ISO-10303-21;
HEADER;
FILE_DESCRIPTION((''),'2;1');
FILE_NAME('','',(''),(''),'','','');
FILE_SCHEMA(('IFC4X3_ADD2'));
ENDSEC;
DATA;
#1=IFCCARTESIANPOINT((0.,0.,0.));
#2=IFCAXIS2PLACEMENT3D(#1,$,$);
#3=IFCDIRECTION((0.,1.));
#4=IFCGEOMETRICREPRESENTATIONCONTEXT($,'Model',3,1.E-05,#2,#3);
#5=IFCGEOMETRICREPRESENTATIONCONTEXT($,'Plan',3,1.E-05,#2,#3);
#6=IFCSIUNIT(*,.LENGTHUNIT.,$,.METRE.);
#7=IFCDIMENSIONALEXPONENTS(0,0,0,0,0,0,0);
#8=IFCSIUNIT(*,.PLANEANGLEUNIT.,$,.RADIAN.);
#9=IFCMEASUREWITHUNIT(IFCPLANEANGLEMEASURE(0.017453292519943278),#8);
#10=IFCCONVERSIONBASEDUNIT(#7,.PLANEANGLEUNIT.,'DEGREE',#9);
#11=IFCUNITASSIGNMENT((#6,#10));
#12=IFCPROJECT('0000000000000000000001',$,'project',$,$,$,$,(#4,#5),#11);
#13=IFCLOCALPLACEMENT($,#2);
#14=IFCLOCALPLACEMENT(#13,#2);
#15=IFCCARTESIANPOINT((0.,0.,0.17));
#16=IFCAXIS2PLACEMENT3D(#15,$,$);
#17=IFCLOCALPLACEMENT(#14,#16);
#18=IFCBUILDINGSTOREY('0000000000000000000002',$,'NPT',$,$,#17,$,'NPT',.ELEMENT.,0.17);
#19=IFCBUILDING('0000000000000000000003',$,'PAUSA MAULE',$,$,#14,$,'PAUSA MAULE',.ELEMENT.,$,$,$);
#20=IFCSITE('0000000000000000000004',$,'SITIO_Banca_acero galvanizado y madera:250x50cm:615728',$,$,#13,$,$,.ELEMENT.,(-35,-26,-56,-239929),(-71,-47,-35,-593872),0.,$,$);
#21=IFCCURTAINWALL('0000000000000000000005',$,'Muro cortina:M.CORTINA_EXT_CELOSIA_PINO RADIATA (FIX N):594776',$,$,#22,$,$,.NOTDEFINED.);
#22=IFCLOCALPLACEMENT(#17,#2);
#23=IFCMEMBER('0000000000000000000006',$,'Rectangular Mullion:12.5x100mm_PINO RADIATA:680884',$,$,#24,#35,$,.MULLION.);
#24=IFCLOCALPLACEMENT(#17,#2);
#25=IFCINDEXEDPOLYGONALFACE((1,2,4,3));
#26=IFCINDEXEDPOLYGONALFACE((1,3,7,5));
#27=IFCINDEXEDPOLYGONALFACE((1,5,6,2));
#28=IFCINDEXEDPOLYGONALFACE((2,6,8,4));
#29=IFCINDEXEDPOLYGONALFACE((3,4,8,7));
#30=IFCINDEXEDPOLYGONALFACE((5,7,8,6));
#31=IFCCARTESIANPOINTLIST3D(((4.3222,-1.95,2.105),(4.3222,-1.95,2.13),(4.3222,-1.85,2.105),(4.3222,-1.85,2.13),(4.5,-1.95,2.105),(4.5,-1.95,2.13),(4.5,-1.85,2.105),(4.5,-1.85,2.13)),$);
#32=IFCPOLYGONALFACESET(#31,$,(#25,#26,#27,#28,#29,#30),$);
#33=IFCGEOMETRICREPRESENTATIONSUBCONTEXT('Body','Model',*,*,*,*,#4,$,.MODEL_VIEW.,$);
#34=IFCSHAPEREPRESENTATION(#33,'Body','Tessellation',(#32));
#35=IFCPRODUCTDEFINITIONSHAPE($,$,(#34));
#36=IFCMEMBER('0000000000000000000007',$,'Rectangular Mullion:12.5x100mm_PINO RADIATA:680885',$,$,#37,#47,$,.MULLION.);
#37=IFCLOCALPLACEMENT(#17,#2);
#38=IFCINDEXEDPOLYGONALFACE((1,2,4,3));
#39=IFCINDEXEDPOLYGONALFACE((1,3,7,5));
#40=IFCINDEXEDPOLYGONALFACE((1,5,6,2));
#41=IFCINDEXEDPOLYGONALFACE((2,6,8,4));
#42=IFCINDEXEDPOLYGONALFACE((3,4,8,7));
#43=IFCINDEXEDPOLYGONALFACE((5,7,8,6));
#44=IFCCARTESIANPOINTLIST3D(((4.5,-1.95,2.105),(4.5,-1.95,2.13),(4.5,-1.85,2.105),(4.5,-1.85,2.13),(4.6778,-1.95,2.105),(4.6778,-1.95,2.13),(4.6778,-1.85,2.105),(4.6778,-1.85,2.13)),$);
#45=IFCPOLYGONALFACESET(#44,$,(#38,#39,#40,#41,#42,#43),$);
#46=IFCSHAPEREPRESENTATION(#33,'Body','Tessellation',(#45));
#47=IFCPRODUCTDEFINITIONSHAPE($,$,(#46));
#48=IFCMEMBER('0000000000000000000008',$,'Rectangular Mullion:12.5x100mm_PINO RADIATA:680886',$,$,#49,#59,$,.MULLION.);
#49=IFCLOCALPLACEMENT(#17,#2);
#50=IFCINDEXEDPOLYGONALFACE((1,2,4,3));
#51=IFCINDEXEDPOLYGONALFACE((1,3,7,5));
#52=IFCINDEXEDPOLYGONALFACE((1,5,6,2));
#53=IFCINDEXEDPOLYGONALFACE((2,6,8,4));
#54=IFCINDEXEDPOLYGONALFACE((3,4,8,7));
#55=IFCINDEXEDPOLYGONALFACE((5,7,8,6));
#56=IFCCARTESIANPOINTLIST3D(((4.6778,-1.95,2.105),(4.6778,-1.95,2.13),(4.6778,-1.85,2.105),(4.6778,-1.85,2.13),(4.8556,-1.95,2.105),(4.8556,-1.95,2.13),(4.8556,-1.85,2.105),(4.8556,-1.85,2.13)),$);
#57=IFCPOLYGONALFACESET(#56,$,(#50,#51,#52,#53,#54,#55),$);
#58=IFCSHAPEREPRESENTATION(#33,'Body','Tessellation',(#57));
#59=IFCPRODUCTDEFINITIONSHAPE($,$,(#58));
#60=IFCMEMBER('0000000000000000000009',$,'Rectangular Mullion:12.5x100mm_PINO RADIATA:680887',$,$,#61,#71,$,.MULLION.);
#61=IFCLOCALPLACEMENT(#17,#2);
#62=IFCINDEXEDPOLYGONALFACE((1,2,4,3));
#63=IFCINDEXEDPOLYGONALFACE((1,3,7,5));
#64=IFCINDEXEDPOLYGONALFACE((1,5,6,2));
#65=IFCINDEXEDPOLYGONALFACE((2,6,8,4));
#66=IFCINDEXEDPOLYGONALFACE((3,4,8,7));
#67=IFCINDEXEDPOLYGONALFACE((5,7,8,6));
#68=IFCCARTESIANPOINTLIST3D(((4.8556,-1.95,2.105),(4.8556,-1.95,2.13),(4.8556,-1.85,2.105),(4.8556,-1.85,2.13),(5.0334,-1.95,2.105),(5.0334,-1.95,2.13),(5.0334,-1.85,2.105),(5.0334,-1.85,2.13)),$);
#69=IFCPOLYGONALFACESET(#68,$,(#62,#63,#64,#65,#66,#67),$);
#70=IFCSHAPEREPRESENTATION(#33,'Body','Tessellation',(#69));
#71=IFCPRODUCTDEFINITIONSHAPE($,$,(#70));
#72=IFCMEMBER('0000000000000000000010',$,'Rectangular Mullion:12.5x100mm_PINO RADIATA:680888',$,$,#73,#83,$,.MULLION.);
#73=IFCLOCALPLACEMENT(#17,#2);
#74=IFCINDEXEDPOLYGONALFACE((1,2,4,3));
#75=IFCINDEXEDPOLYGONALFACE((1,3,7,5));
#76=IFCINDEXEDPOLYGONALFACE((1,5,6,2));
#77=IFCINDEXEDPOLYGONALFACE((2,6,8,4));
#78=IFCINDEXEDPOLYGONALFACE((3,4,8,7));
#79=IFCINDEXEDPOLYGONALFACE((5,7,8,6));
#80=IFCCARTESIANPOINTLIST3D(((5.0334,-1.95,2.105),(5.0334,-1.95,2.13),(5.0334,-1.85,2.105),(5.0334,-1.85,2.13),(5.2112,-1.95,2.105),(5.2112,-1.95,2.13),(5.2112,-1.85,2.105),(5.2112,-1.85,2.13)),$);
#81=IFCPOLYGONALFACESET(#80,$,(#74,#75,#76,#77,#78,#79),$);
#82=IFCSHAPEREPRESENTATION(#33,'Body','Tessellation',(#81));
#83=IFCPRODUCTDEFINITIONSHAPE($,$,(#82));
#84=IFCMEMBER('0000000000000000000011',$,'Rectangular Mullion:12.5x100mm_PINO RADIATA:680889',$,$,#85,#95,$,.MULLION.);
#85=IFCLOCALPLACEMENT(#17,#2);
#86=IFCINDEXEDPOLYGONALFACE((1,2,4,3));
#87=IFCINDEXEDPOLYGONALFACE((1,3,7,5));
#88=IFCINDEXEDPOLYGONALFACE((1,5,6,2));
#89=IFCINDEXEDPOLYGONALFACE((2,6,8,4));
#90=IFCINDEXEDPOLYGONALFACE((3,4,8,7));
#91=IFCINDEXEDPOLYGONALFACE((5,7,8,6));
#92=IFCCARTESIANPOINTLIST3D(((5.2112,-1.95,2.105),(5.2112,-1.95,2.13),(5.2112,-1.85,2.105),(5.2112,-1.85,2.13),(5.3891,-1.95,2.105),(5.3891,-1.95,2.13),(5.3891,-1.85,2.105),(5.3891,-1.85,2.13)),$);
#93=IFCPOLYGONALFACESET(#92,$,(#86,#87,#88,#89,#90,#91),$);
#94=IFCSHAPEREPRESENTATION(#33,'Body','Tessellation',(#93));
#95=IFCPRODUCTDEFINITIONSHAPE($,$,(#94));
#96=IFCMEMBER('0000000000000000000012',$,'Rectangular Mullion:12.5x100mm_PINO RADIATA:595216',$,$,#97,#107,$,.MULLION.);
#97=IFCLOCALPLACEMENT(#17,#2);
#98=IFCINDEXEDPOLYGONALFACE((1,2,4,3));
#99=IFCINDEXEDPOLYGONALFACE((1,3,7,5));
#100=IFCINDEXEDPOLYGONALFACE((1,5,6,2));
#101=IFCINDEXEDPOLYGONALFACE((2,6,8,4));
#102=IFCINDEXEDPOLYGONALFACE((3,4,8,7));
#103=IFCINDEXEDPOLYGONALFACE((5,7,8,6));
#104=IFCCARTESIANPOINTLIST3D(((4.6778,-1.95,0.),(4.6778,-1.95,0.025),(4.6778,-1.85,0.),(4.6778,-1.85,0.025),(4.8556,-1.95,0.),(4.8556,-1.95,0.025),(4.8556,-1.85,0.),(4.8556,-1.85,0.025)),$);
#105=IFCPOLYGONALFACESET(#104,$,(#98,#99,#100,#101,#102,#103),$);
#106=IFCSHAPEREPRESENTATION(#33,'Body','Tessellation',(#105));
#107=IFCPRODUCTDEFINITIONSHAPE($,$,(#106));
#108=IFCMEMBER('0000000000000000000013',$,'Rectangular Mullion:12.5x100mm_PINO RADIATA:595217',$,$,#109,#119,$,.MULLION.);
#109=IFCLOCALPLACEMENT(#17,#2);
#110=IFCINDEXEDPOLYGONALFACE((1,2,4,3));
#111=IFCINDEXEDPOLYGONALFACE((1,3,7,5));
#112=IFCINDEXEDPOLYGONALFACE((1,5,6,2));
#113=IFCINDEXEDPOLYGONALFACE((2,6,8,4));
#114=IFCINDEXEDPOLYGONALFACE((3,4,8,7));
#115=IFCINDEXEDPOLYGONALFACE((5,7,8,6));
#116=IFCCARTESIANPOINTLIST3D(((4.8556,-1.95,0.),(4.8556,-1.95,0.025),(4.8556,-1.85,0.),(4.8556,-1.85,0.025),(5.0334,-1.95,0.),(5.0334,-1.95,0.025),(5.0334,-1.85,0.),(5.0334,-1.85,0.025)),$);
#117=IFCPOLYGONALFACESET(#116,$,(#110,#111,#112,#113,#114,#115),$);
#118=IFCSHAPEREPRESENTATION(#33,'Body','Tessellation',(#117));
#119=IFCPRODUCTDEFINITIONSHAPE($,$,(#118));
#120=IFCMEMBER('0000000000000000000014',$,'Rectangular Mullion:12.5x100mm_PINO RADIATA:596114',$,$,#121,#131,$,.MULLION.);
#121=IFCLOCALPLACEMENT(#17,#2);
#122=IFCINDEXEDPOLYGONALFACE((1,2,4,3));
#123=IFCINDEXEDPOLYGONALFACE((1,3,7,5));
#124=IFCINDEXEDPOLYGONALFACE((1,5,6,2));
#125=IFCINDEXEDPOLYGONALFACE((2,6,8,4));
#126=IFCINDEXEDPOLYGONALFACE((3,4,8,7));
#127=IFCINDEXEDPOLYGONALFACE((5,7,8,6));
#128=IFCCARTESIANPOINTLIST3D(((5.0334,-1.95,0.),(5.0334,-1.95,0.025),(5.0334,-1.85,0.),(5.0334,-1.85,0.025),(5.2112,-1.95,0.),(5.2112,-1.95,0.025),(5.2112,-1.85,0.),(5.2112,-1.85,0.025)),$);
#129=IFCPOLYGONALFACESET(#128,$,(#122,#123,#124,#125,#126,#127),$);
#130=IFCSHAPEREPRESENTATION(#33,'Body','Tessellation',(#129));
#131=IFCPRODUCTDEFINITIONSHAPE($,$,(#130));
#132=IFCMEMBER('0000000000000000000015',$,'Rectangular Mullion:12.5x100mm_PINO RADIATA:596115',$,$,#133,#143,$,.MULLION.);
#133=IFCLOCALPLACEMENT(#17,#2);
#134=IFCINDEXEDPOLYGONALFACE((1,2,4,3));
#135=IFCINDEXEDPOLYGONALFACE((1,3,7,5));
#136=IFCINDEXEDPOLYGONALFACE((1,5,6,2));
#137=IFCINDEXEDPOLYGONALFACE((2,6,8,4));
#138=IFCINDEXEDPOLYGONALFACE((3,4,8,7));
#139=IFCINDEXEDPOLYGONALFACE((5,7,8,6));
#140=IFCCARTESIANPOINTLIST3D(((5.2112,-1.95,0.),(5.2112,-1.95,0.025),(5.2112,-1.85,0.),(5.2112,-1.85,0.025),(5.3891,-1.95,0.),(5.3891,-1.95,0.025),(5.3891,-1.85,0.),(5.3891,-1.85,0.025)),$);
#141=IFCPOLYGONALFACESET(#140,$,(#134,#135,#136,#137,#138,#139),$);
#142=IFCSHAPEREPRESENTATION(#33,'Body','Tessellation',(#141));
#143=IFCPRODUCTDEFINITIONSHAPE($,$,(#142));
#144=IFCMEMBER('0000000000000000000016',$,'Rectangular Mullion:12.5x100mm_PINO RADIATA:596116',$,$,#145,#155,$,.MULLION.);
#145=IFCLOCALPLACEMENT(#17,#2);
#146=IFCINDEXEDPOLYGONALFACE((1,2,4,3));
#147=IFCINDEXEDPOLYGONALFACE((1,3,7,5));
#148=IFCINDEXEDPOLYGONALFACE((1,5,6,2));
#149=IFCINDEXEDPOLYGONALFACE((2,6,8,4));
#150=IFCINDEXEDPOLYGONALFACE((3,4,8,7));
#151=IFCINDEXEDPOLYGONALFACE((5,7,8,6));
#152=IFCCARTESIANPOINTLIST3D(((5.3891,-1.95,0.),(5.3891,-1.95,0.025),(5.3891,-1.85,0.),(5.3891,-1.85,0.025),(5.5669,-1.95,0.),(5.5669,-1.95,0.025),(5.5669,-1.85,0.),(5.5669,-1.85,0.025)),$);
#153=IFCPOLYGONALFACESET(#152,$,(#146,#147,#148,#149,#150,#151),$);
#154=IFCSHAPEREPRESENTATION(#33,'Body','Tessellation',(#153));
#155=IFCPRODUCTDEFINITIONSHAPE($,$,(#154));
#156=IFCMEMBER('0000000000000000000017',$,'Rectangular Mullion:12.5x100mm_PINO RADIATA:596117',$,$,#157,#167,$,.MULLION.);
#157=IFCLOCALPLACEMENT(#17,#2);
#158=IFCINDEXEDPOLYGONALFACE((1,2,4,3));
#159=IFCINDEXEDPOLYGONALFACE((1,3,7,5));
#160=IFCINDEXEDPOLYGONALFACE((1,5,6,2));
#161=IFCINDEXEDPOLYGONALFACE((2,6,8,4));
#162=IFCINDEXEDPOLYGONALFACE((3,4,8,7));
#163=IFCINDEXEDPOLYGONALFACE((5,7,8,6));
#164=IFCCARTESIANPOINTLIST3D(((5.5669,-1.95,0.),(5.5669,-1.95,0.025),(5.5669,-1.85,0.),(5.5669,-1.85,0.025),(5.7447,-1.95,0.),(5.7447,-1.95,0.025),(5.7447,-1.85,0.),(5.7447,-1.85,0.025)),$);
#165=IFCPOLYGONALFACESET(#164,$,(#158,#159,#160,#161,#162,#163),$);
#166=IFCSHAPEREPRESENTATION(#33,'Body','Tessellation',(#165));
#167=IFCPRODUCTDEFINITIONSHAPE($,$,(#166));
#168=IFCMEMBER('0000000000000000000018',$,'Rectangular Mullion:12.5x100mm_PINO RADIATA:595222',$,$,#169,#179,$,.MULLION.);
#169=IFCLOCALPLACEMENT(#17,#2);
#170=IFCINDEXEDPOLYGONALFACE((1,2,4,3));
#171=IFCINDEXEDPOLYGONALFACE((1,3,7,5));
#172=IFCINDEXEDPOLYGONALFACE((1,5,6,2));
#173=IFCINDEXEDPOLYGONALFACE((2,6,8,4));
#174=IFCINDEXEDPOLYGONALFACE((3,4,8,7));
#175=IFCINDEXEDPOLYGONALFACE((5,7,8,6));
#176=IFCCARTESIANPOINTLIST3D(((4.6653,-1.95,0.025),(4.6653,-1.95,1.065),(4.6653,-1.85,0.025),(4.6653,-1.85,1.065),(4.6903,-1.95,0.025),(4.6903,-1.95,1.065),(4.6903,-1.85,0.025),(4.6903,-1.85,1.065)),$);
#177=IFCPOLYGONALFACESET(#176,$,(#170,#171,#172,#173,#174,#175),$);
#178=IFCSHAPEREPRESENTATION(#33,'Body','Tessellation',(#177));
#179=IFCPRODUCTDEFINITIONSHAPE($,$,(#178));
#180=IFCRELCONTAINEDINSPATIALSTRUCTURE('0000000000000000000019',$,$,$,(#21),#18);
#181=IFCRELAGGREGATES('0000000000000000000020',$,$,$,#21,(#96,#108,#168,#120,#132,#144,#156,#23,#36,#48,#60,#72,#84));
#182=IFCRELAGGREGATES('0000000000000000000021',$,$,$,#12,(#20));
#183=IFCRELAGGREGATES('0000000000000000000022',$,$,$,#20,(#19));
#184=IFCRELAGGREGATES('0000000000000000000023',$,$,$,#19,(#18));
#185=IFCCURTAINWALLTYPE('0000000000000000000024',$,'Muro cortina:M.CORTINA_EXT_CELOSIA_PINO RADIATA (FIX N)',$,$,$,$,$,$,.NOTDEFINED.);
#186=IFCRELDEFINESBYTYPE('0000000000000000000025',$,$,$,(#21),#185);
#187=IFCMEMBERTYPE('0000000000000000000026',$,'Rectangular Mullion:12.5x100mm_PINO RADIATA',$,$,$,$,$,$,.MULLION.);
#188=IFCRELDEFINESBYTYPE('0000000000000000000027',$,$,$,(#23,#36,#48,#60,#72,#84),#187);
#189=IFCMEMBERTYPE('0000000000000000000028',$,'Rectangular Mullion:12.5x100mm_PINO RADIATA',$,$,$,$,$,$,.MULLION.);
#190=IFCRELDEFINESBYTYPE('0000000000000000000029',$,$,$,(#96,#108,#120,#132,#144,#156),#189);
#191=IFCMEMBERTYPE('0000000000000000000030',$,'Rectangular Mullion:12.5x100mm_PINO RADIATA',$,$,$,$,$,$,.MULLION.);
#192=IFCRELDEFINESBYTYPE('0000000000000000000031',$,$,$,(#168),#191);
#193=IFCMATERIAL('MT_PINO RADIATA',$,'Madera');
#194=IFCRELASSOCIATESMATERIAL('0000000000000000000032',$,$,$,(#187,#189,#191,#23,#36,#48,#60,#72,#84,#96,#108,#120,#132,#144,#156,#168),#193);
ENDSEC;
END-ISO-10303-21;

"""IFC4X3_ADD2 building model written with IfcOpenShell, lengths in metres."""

from ifc_helpers import new_model, entity, si_unit, converted_unit, direction, frame, frame_2d, origin, place, context, subcontext, project, spatial, rectangle, extrude, source, transform, mapped, material, material_profile, profile_set, profile_usage, type_object, type_shapes, element, aggregate, save


model = new_model("IFC4X3_ADD2")

# Units and contexts
model_context = context("Model", 3, precision=1e-05, world=origin(), true_north=direction((0.0, 1.0)))
plan_context = context("Plan", 3, precision=1e-05, world=origin(), true_north=direction((0.0, 1.0)))
body_context = subcontext(model_context, "Body", "Model", "MODEL_VIEW")
ifc_project = project(units=[si_unit("LENGTHUNIT", "METRE"), converted_unit("PLANEANGLEUNIT", "DEGREE", entity("IfcPlaneAngleMeasure", 0.017453292519943278), si_unit("PLANEANGLEUNIT", "RADIAN"), dimensions=[0, 0, 0, 0, 0, 0, 0])], contexts=[model_context, plan_context])

# Site, building, storey
site_placement = place(None, origin())
site = spatial("IfcSite", under=ifc_project, at=site_placement, Name="SITIO_Banca_acero galvanizado y madera:250x50cm:615728", CompositionType="ELEMENT", RefLatitude=(-35, -26, -56, -239929), RefLongitude=(-71, -47, -35, -593872), RefElevation=0.0)
building_placement = place(site_placement, origin())
building = spatial("IfcBuilding", under=site, at=building_placement, Name="PAUSA MAULE", LongName="PAUSA MAULE", CompositionType="ELEMENT")
storey_placement = place(building_placement, frame((0.0, 0.0, 0.17)))
storey = spatial("IfcBuildingStorey", under=building, at=storey_placement, Name="NPT", LongName="NPT", CompositionType="ELEMENT", Elevation=0.17)

# Curtain wall, members
curtain_wall_type = type_object("IfcCurtainWallType", Name="Muro cortina:M.CORTINA_EXT_CELOSIA_PINO RADIATA (FIX N)", PredefinedType="NOTDEFINED")
curtain_wall_placement = place(storey_placement, frame((0.0, 0.0, -0.17)))
curtain_wall = element("IfcCurtainWall", 1, at=curtain_wall_placement, inside=storey, type_object=curtain_wall_type, Name="Muro cortina:M.CORTINA_EXT_CELOSIA_PINO RADIATA (FIX N):594776", PredefinedType="NOTDEFINED")
ifc_material = material(Name="MT_PINO RADIATA", Category="Madera")
ifc_material_profile = material_profile(ifc_material, rectangle(XDim=0.025, YDim=0.1, at=frame_2d((0.0, 0.0), x_axis=(1.0, 0.0))), Name="12.5x100mm_PINO RADIATA")
ifc_profile_set = profile_set([ifc_material_profile], Name="12.5x100mm_PINO RADIATA")
ifc_profile_usage = profile_usage(ifc_profile_set)
member_type_1 = type_object("IfcMemberType", Name="Rectangular Mullion:12.5x100mm_PINO RADIATA", PredefinedType="MULLION", material=ifc_profile_set)
shared_shape_1 = source(origin(), body_context, "Body", "SweptSolid", [
    extrude(rectangle(XDim=0.025, YDim=0.1, at=frame_2d((0.0, 0.0), x_axis=(1.0, 0.0))), frame((-0.0125, 0.0, -0.1778), z_axis=(0.0, 0.0, 1.0), x_axis=(-1.0, 0.0, 0.0)), (0.0, 0.0, 1.0), 0.1778),
])
type_shapes(member_type_1, [shared_shape_1])
member_1_placement = place(curtain_wall_placement, frame((4.5, -1.9, 2.3), z_axis=(1.0, 0.0, 0.0), x_axis=(0.0, 0.0, 1.0)))
member_1 = element("IfcMember", 2, at=member_1_placement, type_object=member_type_1, material=ifc_profile_usage, Name="Rectangular Mullion:12.5x100mm_PINO RADIATA:680884", PredefinedType="MULLION", context=body_context, shape_type="MappedRepresentation", body=[
    mapped(shared_shape_1, transform((0.0, 0.0, 0.0), scale=1.0)),
])
member_2_placement = place(curtain_wall_placement, frame((4.6778, -1.9, 2.3), z_axis=(1.0, 0.0, 0.0), x_axis=(0.0, 0.0, 1.0)))
member_2 = element("IfcMember", 3, at=member_2_placement, type_object=member_type_1, material=ifc_profile_usage, Name="Rectangular Mullion:12.5x100mm_PINO RADIATA:680885", PredefinedType="MULLION", context=body_context, shape_type="MappedRepresentation", body=[
    mapped(shared_shape_1, transform((0.0, 0.0, 0.0), scale=1.0)),
])
member_3_placement = place(curtain_wall_placement, frame((4.8556, -1.9, 2.3), z_axis=(1.0, 0.0, 0.0), x_axis=(0.0, 0.0, 1.0)))
member_3 = element("IfcMember", 4, at=member_3_placement, type_object=member_type_1, material=ifc_profile_usage, Name="Rectangular Mullion:12.5x100mm_PINO RADIATA:680886", PredefinedType="MULLION", context=body_context, shape_type="MappedRepresentation", body=[
    mapped(shared_shape_1, transform((0.0, 0.0, 0.0), scale=1.0)),
])
member_4_placement = place(curtain_wall_placement, frame((5.0334, -1.9, 2.3), z_axis=(1.0, 0.0, 0.0), x_axis=(0.0, 0.0, 1.0)))
member_4 = element("IfcMember", 5, at=member_4_placement, type_object=member_type_1, material=ifc_profile_usage, Name="Rectangular Mullion:12.5x100mm_PINO RADIATA:680887", PredefinedType="MULLION", context=body_context, shape_type="MappedRepresentation", body=[
    mapped(shared_shape_1, transform((0.0, 0.0, 0.0), scale=1.0)),
])
member_5_placement = place(curtain_wall_placement, frame((5.2112, -1.9, 2.3), z_axis=(1.0, 0.0, 0.0), x_axis=(0.0, 0.0, 1.0)))
member_5 = element("IfcMember", 6, at=member_5_placement, type_object=member_type_1, material=ifc_profile_usage, Name="Rectangular Mullion:12.5x100mm_PINO RADIATA:680888", PredefinedType="MULLION", context=body_context, shape_type="MappedRepresentation", body=[
    mapped(shared_shape_1, transform((0.0, 0.0, 0.0), scale=1.0)),
])
member_6_placement = place(curtain_wall_placement, frame((5.3891, -1.9, 2.3), z_axis=(1.0, 0.0, 0.0), x_axis=(0.0, 0.0, 1.0)))
member_6 = element("IfcMember", 7, at=member_6_placement, type_object=member_type_1, material=ifc_profile_usage, Name="Rectangular Mullion:12.5x100mm_PINO RADIATA:680889", PredefinedType="MULLION", context=body_context, shape_type="MappedRepresentation", body=[
    mapped(shared_shape_1, transform((0.0, 0.0, 0.0), scale=1.0)),
])
member_type_2 = type_object("IfcMemberType", Name="Rectangular Mullion:12.5x100mm_PINO RADIATA", PredefinedType="MULLION", material=ifc_profile_set)
shared_shape_2 = source(origin(), body_context, "Body", "SweptSolid", [
    extrude(rectangle(XDim=0.025, YDim=0.1, at=frame_2d((0.0, 0.0), x_axis=(1.0, 0.0))), frame((-0.0125, 0.0, -0.1778), z_axis=(0.0, 0.0, 1.0), x_axis=(-1.0, 0.0, 0.0)), (0.0, 0.0, 1.0), 0.1778),
])
type_shapes(member_type_2, [shared_shape_2])
member_7_placement = place(curtain_wall_placement, frame((4.6778, -1.9, 0.17), z_axis=(-1.0, 0.0, 0.0), x_axis=(0.0, 0.0, -1.0)))
member_7 = element("IfcMember", 8, at=member_7_placement, type_object=member_type_2, material=ifc_profile_usage, Name="Rectangular Mullion:12.5x100mm_PINO RADIATA:595216", PredefinedType="MULLION", context=body_context, shape_type="MappedRepresentation", body=[
    mapped(shared_shape_2, transform((0.0, 0.0, 0.0), scale=1.0)),
])
member_8_placement = place(curtain_wall_placement, frame((4.8556, -1.9, 0.17), z_axis=(-1.0, 0.0, 0.0), x_axis=(0.0, 0.0, -1.0)))
member_8 = element("IfcMember", 9, at=member_8_placement, type_object=member_type_2, material=ifc_profile_usage, Name="Rectangular Mullion:12.5x100mm_PINO RADIATA:595217", PredefinedType="MULLION", context=body_context, shape_type="MappedRepresentation", body=[
    mapped(shared_shape_2, transform((0.0, 0.0, 0.0), scale=1.0)),
])
member_9_placement = place(curtain_wall_placement, frame((5.0334, -1.9, 0.17), z_axis=(-1.0, 0.0, 0.0), x_axis=(0.0, 0.0, -1.0)))
member_9 = element("IfcMember", 10, at=member_9_placement, type_object=member_type_2, material=ifc_profile_usage, Name="Rectangular Mullion:12.5x100mm_PINO RADIATA:596114", PredefinedType="MULLION", context=body_context, shape_type="MappedRepresentation", body=[
    mapped(shared_shape_2, transform((0.0, 0.0, 0.0), scale=1.0)),
])
member_10_placement = place(curtain_wall_placement, frame((5.2112, -1.9, 0.17), z_axis=(-1.0, 0.0, 0.0), x_axis=(0.0, 0.0, -1.0)))
member_10 = element("IfcMember", 11, at=member_10_placement, type_object=member_type_2, material=ifc_profile_usage, Name="Rectangular Mullion:12.5x100mm_PINO RADIATA:596115", PredefinedType="MULLION", context=body_context, shape_type="MappedRepresentation", body=[
    mapped(shared_shape_2, transform((0.0, 0.0, 0.0), scale=1.0)),
])
member_11_placement = place(curtain_wall_placement, frame((5.3891, -1.9, 0.17), z_axis=(-1.0, 0.0, 0.0), x_axis=(0.0, 0.0, -1.0)))
member_11 = element("IfcMember", 12, at=member_11_placement, type_object=member_type_2, material=ifc_profile_usage, Name="Rectangular Mullion:12.5x100mm_PINO RADIATA:596116", PredefinedType="MULLION", context=body_context, shape_type="MappedRepresentation", body=[
    mapped(shared_shape_2, transform((0.0, 0.0, 0.0), scale=1.0)),
])
member_12_placement = place(curtain_wall_placement, frame((5.5669, -1.9, 0.17), z_axis=(-1.0, 0.0, 0.0), x_axis=(0.0, 0.0, -1.0)))
member_12 = element("IfcMember", 13, at=member_12_placement, type_object=member_type_2, material=ifc_profile_usage, Name="Rectangular Mullion:12.5x100mm_PINO RADIATA:596117", PredefinedType="MULLION", context=body_context, shape_type="MappedRepresentation", body=[
    mapped(shared_shape_2, transform((0.0, 0.0, 0.0), scale=1.0)),
])
member_type_3 = type_object("IfcMemberType", Name="Rectangular Mullion:12.5x100mm_PINO RADIATA", PredefinedType="MULLION", material=ifc_profile_set)
shared_shape_3 = source(origin(), body_context, "Body", "SweptSolid", [
    extrude(rectangle(XDim=0.025, YDim=0.1, at=frame_2d((0.0, 0.0), x_axis=(1.0, 0.0))), frame((0.0, 0.0, -1.04), z_axis=(0.0, 0.0, 1.0), x_axis=(-1.0, 0.0, 0.0)), (0.0, 0.0, 1.0), 1.04),
])
type_shapes(member_type_3, [shared_shape_3])
member_13_placement = place(curtain_wall_placement, frame((4.6778, -1.9, 0.195), z_axis=(0.0, 0.0, -1.0), x_axis=(1.0, 0.0, 0.0)))
member_13 = element("IfcMember", 14, at=member_13_placement, type_object=member_type_3, material=ifc_profile_usage, Name="Rectangular Mullion:12.5x100mm_PINO RADIATA:595222", PredefinedType="MULLION", context=body_context, shape_type="MappedRepresentation", body=[
    mapped(shared_shape_3, transform((0.0, 0.0, 0.0), scale=1.0)),
])
aggregate(curtain_wall, [member_7, member_8, member_13, member_9, member_10, member_11, member_12, member_1, member_2, member_3, member_4, member_5, member_6])

save(model, "model.ifc")
